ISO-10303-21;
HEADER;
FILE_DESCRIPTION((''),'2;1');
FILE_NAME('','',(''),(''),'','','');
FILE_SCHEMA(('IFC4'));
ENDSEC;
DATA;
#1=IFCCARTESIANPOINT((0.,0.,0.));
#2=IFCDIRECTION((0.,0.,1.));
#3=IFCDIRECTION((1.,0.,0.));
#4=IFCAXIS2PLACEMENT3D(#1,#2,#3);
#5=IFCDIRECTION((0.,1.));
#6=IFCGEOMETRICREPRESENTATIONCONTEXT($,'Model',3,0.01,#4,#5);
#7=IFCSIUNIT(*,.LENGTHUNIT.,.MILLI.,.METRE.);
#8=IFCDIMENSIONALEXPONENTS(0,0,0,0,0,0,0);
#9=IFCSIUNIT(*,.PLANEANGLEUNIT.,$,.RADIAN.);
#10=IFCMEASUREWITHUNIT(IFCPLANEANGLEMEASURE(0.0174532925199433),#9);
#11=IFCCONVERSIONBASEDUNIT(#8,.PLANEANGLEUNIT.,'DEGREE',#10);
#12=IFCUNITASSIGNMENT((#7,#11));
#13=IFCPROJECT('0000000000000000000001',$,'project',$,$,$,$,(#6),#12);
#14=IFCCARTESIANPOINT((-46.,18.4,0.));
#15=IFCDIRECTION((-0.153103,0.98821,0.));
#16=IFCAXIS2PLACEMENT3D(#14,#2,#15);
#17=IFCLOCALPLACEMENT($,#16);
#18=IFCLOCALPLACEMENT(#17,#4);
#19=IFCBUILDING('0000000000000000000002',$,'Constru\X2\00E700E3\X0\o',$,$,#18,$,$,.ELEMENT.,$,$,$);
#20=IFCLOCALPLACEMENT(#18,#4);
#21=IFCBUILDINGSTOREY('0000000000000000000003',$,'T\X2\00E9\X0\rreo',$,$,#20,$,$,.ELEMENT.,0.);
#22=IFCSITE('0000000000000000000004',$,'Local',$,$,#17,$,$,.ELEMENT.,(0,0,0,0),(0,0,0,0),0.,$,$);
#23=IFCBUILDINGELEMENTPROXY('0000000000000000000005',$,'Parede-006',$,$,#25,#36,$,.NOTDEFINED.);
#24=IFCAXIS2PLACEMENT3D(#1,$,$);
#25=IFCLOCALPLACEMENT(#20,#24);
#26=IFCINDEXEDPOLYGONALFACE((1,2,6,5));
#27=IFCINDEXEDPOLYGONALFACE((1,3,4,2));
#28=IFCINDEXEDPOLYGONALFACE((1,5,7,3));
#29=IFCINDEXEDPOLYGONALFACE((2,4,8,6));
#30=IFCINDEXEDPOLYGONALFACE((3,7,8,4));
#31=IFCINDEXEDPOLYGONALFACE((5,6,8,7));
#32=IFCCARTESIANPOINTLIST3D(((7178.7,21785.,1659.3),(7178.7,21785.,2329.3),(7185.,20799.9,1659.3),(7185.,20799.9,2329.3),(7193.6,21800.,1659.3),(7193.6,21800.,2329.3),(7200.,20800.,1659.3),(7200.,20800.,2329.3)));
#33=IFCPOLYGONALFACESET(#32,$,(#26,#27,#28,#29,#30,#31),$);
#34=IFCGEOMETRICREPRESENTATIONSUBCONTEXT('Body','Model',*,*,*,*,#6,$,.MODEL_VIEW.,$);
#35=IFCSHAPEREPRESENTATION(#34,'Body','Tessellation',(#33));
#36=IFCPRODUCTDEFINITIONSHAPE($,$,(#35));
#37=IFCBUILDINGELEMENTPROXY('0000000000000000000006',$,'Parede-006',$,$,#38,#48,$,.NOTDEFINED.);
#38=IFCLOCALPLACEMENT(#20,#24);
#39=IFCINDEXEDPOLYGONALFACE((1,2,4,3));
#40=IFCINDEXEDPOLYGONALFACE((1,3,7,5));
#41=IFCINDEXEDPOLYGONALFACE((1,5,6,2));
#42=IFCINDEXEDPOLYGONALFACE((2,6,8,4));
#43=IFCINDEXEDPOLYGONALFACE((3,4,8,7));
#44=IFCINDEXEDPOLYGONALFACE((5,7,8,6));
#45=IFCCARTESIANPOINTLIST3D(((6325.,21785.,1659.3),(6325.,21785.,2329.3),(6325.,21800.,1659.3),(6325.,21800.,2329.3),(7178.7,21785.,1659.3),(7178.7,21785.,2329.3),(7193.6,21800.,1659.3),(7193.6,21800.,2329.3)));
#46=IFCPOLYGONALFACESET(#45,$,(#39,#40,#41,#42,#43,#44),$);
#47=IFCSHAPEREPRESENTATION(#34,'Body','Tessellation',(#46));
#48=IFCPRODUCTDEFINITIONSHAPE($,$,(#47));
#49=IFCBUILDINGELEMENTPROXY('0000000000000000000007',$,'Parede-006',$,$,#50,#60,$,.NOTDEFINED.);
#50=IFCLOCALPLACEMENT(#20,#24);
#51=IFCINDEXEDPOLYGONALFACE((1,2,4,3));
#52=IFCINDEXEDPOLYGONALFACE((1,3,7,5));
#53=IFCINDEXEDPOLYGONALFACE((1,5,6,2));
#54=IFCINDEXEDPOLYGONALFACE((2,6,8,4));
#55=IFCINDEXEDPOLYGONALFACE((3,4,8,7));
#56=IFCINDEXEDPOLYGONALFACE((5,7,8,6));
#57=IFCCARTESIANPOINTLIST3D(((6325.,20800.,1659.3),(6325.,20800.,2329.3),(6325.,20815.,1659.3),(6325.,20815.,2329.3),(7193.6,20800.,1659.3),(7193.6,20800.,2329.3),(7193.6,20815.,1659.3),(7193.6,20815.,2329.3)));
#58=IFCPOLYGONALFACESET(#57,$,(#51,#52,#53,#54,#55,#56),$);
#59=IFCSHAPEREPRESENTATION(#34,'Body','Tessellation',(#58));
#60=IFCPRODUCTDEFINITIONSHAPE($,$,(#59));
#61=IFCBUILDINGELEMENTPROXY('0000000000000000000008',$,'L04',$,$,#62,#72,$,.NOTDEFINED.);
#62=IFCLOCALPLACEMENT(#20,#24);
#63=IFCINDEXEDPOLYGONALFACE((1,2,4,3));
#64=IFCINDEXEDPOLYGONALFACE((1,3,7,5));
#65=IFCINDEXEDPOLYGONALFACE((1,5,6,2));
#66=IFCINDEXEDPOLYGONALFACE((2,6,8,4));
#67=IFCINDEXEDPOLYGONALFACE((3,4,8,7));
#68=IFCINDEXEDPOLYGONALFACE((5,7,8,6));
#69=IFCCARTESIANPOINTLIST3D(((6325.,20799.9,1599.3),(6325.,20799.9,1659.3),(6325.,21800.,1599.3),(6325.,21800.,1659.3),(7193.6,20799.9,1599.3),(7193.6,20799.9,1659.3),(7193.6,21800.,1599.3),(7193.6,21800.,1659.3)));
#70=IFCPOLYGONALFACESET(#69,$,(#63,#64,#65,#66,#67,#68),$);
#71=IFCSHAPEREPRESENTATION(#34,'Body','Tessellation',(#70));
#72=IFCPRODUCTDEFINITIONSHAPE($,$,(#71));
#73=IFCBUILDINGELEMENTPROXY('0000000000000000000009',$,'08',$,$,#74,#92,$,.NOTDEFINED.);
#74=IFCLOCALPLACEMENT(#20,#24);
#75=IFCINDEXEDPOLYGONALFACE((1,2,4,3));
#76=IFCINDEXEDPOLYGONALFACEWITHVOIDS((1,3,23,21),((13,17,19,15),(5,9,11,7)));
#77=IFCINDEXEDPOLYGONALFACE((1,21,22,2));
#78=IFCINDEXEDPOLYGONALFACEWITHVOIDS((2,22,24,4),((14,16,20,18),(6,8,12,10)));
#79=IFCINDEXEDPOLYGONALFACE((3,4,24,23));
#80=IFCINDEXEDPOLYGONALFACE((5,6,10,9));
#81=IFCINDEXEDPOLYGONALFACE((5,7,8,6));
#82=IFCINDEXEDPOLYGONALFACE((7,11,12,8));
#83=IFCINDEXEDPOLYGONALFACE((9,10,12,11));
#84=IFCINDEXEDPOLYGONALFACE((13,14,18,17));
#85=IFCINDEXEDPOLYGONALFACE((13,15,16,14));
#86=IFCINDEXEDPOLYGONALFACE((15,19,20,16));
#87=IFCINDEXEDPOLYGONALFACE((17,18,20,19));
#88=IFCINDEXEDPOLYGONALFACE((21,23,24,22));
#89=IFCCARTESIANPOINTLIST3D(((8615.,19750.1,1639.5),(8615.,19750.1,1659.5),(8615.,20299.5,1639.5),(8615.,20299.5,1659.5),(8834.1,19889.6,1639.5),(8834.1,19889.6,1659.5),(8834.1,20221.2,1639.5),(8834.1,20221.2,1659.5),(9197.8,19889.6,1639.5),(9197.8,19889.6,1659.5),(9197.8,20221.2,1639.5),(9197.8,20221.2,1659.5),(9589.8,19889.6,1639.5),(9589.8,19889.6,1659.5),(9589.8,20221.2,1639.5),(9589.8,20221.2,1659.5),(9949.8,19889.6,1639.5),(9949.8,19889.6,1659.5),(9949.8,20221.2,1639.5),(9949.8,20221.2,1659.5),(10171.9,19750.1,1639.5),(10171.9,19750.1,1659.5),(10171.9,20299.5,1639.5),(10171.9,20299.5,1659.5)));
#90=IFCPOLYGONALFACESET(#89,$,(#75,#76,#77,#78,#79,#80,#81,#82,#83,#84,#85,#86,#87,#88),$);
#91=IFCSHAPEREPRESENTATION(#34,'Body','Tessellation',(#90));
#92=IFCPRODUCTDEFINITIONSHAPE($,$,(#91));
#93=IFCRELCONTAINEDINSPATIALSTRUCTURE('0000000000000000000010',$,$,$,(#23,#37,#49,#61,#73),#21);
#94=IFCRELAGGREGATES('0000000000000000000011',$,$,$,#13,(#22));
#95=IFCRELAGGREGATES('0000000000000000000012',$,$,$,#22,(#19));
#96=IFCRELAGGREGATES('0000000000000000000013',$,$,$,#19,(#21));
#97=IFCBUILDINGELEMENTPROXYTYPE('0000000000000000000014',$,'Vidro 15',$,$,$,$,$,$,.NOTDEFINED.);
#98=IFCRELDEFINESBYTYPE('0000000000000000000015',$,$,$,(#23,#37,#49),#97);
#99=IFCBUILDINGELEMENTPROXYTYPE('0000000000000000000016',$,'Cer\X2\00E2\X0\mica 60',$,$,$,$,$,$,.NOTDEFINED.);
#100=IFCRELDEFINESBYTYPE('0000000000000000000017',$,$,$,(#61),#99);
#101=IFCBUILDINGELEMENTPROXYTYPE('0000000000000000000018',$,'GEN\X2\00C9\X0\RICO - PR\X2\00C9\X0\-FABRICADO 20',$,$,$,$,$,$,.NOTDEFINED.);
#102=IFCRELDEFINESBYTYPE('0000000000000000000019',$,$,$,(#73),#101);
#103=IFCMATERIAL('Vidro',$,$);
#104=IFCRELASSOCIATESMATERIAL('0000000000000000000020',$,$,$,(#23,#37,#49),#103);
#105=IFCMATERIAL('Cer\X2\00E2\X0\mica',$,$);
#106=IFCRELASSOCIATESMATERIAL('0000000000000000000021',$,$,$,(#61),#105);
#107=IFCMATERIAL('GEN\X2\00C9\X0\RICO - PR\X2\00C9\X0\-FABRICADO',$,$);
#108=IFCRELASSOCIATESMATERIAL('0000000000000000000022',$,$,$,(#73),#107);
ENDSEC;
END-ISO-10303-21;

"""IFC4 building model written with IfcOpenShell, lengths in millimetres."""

from ifc_helpers import new_model, entity, si_unit, converted_unit, direction, frame, origin_with_axes, place, context, subcontext, project, spatial, line, indexed_curve, outline, extrude, material, type_object, element, save


model = new_model("IFC4")

# Units and contexts
model_context = context("Model", 3, precision=0.01, world=origin_with_axes(), true_north=direction((0.0, 1.0)))
body_context = subcontext(model_context, "Body", "Model", "MODEL_VIEW")
ifc_project = project(units=[si_unit("LENGTHUNIT", "METRE", prefix="MILLI"), converted_unit("PLANEANGLEUNIT", "DEGREE", entity("IfcPlaneAngleMeasure", 0.0174532925199433), si_unit("PLANEANGLEUNIT", "RADIAN"), dimensions=[0, 0, 0, 0, 0, 0, 0])], contexts=[model_context])

# Site, building, storey
site_placement = place(None, frame((-46.0, 18.4, 0.0), z_axis=(0.0, 0.0, 1.0), x_axis=(-0.153103, 0.98821, 0.0)))
site = spatial("IfcSite", under=ifc_project, at=site_placement, Name="Local", CompositionType="ELEMENT", RefLatitude=(0, 0, 0, 0), RefLongitude=(0, 0, 0, 0), RefElevation=0.0)
building_placement = place(site_placement, origin_with_axes())
building = spatial("IfcBuilding", under=site, at=building_placement, Name="Construção", CompositionType="ELEMENT")
storey_placement = place(building_placement, origin_with_axes())
storey = spatial("IfcBuildingStorey", under=building, at=storey_placement, Name="Térreo", CompositionType="ELEMENT", Elevation=0.0)

# Building element proxies
ifc_material_1 = material(Name="Cerâmica")
ifc_material_2 = material(Name="Vidro")
building_element_proxy_type_1 = type_object("IfcBuildingElementProxyType", Name="Vidro 15", PredefinedType="NOTDEFINED")
proxy_1_placement = place(storey_placement, frame((7200.0, 20800.0, 1659.3), z_axis=(0.0, 0.0, 1.0), x_axis=(-0.006409, 0.999979, 0.0)))
element("IfcBuildingElementProxy", 1, at=proxy_1_placement, inside=storey, type_object=building_element_proxy_type_1, material=ifc_material_2, Name="Parede-006", PredefinedType="NOTDEFINED", context=body_context, shape_type="SweptSolid", body=[
    extrude(outline(indexed_curve([(0.0, 0.0), (1000.0, 0.0), (985.1, 15.0), (0.0, 15.0)], segments=[line(1, 2, 3, 4, 1)])), origin_with_axes(), (0.0, 0.0, 1.0), 670.0),
])
proxy_2_placement = place(storey_placement, frame((6325.0, 21800.0, 1659.3), z_axis=(0.0, 0.0, 1.0), x_axis=(1.0, -0.000001, 0.0)))
element("IfcBuildingElementProxy", 2, at=proxy_2_placement, inside=storey, type_object=building_element_proxy_type_1, material=ifc_material_2, Name="Parede-006", PredefinedType="NOTDEFINED", context=body_context, shape_type="SweptSolid", body=[
    extrude(outline(indexed_curve([(0.0, -15.0), (853.7, -15.0), (868.6, 0.0), (0.0, 0.0)], segments=[line(1, 2, 3, 4, 1)])), origin_with_axes(), (0.0, 0.0, 1.0), 670.0),
])
proxy_3_placement = place(storey_placement, frame((6325.0, 20815.0, 1659.3), z_axis=(0.0, 0.0, 1.0), x_axis=(1.0, -0.000001, 0.0)))
element("IfcBuildingElementProxy", 3, at=proxy_3_placement, inside=storey, type_object=building_element_proxy_type_1, material=ifc_material_2, Name="Parede-006", PredefinedType="NOTDEFINED", context=body_context, shape_type="SweptSolid", body=[
    extrude(outline(indexed_curve([(0.0, -15.0), (868.6, -15.0), (868.6, 0.0), (0.0, 0.0)], segments=[line(1, 2, 3, 4, 1)])), origin_with_axes(), (0.0, 0.0, 1.0), 670.0),
])
building_element_proxy_type_2 = type_object("IfcBuildingElementProxyType", Name="Cerâmica 60", PredefinedType="NOTDEFINED")
proxy_4_placement = place(storey_placement, frame((6325.0, 20799.9, 1659.3), z_axis=(0.0, 0.0, 1.0), x_axis=(1.0, 0.0, 0.0)))
element("IfcBuildingElementProxy", 4, at=proxy_4_placement, inside=storey, type_object=building_element_proxy_type_2, material=ifc_material_1, Name="L04", PredefinedType="NOTDEFINED", context=body_context, shape_type="SweptSolid", body=[
    extrude(outline(indexed_curve([(0.0, 0.0), (868.6, 0.0), (868.6, 1000.1), (0.0, 1000.1)], segments=[line(1, 2, 3, 4, 1)])), frame((0.0, 0.0, -60.0), z_axis=(0.0, 0.0, 1.0), x_axis=(1.0, 0.0, 0.0)), (0.0, 0.0, 1.0), 60.0),
])
ifc_material_3 = material(Name="GENÉRICO - PRÉ-FABRICADO")
building_element_proxy_type_3 = type_object("IfcBuildingElementProxyType", Name="GENÉRICO - PRÉ-FABRICADO 20", PredefinedType="NOTDEFINED")
proxy_5_placement = place(storey_placement, frame((8615.0, 19750.1, 1659.5), z_axis=(0.0, 0.0, 1.0), x_axis=(1.0, 0.0, 0.0)))
element("IfcBuildingElementProxy", 5, at=proxy_5_placement, inside=storey, type_object=building_element_proxy_type_3, material=ifc_material_3, Name="08", PredefinedType="NOTDEFINED", context=body_context, shape_type="SweptSolid", body=[
    extrude(outline(indexed_curve([(0.0, 0.0), (1557.0, 0.0), (1557.0, 549.5), (0.0, 549.5), (1334.9, 471.1), (1334.9, 139.5), (974.8, 139.5), (974.8, 471.1), (582.8, 471.1), (582.8, 139.5), (219.1, 139.5), (219.1, 471.1)], segments=[line(1, 2, 3, 4, 1)]), holes=[indexed_curve([(0.0, 0.0), (1557.0, 0.0), (1557.0, 549.5), (0.0, 549.5), (1334.9, 471.1), (1334.9, 139.5), (974.8, 139.5), (974.8, 471.1), (582.8, 471.1), (582.8, 139.5), (219.1, 139.5), (219.1, 471.1)], segments=[line(5, 6, 7, 8, 5)]), indexed_curve([(0.0, 0.0), (1557.0, 0.0), (1557.0, 549.5), (0.0, 549.5), (1334.9, 471.1), (1334.9, 139.5), (974.8, 139.5), (974.8, 471.1), (582.8, 471.1), (582.8, 139.5), (219.1, 139.5), (219.1, 471.1)], segments=[line(9, 10, 11, 12, 9)])]), frame((0.0, 0.0, -20.0), z_axis=(0.0, 0.0, 1.0), x_axis=(1.0, 0.0, 0.0)), (0.0, 0.0, 1.0), 20.0),
])

save(model, "model.ifc")
